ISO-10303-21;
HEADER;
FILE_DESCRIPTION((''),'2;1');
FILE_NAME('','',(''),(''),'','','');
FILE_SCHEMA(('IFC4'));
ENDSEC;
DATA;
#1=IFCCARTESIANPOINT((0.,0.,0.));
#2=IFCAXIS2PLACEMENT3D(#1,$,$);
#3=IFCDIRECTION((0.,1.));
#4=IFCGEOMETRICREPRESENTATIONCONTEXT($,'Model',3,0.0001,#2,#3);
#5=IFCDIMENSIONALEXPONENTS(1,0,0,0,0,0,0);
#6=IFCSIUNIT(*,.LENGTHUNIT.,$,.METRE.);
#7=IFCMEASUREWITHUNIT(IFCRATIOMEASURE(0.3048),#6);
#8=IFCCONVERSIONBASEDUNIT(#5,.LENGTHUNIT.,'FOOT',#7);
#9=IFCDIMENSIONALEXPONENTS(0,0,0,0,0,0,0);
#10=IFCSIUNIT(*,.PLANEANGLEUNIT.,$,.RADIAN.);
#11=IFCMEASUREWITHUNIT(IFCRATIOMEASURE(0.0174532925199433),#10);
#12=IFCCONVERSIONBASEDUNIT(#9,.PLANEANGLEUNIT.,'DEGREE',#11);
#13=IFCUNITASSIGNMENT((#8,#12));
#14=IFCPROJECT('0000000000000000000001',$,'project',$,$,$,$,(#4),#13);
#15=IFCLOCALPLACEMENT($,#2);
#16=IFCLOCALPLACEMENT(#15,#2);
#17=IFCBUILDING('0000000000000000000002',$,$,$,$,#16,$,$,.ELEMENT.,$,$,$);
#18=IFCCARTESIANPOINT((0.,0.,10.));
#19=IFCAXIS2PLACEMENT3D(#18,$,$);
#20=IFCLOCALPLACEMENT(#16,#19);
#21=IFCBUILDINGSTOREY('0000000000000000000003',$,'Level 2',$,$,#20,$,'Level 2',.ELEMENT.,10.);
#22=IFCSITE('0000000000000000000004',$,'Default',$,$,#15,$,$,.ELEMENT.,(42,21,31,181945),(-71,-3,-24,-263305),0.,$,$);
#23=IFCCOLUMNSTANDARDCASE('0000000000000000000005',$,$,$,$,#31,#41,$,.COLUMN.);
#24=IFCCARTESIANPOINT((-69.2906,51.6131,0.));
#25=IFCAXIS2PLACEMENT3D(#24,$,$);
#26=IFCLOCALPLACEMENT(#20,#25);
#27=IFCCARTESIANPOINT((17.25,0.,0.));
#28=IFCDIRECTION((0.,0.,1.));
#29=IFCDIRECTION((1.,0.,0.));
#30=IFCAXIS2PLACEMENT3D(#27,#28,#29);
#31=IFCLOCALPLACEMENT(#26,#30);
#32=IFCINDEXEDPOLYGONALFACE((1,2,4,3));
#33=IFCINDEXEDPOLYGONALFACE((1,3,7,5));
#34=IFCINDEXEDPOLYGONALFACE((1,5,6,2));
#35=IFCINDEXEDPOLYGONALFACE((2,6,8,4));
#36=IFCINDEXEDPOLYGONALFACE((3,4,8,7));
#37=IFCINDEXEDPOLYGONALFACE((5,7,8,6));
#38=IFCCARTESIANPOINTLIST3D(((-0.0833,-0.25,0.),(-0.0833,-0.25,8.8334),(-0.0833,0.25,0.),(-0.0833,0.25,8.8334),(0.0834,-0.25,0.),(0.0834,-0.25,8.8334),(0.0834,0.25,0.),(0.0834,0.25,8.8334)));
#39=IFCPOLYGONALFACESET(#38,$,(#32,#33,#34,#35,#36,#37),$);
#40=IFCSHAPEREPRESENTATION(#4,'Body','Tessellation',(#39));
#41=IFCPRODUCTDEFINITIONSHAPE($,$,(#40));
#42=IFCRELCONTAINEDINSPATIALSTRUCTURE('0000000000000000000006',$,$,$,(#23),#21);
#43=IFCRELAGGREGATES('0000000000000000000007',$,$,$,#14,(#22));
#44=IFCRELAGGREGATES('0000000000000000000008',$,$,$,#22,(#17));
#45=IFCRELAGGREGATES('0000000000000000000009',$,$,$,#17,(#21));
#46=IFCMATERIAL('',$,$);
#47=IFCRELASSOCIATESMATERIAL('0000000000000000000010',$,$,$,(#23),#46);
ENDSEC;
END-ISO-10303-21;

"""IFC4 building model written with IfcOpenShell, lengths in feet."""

from ifc_helpers import new_model, entity, si_unit, converted_unit, direction, frame, origin, place, context, project, spatial, rectangle, extrude, material, element, save


model = new_model("IFC4")

# Units and contexts
model_context = context("Model", 3, precision=0.0001, world=origin(), true_north=direction((0.0, 1.0)))
ifc_project = project(units=[converted_unit("LENGTHUNIT", "FOOT", entity("IfcRatioMeasure", 0.3048), si_unit("LENGTHUNIT", "METRE"), dimensions=[1, 0, 0, 0, 0, 0, 0]), converted_unit("PLANEANGLEUNIT", "DEGREE", entity("IfcRatioMeasure", 0.0174532925199433), si_unit("PLANEANGLEUNIT", "RADIAN"), dimensions=[0, 0, 0, 0, 0, 0, 0])], contexts=[model_context])

# Site, building, storey
site_placement = place(None, origin())
site = spatial("IfcSite", under=ifc_project, at=site_placement, Name="Default", CompositionType="ELEMENT", RefLatitude=(42, 21, 31, 181945), RefLongitude=(-71, -3, -24, -263305), RefElevation=0.0)
building_placement = place(site_placement, origin())
building = spatial("IfcBuilding", under=site, at=building_placement, CompositionType="ELEMENT")
storey_placement = place(building_placement, frame((0.0, 0.0, 10.0)))
storey = spatial("IfcBuildingStorey", under=building, at=storey_placement, Name="Level 2", LongName="Level 2", CompositionType="ELEMENT", Elevation=10.0)

# Column
ifc_material_1 = material(Name="")
placement_1 = place(storey_placement, frame((-69.2906, 51.6131, 0.0)))
for number, where, z_axis, x_axis in (
    (1, (17.25, 0.0, 0.0), (0.0, 0.0, 1.0), (1.0, 0.0, 0.0)),
):
    element("IfcColumnStandardCase", number, at=place(placement_1, frame(where, z_axis=z_axis, x_axis=x_axis)), inside=storey, material=ifc_material_1, PredefinedType="COLUMN", context=model_context, shape_type="SweptSolid", body=[
        extrude(rectangle(XDim=0.1667, YDim=0.5), origin(), (0.0, 0.0, 1.0), 8.8334),
    ])

save(model, "model.ifc")
